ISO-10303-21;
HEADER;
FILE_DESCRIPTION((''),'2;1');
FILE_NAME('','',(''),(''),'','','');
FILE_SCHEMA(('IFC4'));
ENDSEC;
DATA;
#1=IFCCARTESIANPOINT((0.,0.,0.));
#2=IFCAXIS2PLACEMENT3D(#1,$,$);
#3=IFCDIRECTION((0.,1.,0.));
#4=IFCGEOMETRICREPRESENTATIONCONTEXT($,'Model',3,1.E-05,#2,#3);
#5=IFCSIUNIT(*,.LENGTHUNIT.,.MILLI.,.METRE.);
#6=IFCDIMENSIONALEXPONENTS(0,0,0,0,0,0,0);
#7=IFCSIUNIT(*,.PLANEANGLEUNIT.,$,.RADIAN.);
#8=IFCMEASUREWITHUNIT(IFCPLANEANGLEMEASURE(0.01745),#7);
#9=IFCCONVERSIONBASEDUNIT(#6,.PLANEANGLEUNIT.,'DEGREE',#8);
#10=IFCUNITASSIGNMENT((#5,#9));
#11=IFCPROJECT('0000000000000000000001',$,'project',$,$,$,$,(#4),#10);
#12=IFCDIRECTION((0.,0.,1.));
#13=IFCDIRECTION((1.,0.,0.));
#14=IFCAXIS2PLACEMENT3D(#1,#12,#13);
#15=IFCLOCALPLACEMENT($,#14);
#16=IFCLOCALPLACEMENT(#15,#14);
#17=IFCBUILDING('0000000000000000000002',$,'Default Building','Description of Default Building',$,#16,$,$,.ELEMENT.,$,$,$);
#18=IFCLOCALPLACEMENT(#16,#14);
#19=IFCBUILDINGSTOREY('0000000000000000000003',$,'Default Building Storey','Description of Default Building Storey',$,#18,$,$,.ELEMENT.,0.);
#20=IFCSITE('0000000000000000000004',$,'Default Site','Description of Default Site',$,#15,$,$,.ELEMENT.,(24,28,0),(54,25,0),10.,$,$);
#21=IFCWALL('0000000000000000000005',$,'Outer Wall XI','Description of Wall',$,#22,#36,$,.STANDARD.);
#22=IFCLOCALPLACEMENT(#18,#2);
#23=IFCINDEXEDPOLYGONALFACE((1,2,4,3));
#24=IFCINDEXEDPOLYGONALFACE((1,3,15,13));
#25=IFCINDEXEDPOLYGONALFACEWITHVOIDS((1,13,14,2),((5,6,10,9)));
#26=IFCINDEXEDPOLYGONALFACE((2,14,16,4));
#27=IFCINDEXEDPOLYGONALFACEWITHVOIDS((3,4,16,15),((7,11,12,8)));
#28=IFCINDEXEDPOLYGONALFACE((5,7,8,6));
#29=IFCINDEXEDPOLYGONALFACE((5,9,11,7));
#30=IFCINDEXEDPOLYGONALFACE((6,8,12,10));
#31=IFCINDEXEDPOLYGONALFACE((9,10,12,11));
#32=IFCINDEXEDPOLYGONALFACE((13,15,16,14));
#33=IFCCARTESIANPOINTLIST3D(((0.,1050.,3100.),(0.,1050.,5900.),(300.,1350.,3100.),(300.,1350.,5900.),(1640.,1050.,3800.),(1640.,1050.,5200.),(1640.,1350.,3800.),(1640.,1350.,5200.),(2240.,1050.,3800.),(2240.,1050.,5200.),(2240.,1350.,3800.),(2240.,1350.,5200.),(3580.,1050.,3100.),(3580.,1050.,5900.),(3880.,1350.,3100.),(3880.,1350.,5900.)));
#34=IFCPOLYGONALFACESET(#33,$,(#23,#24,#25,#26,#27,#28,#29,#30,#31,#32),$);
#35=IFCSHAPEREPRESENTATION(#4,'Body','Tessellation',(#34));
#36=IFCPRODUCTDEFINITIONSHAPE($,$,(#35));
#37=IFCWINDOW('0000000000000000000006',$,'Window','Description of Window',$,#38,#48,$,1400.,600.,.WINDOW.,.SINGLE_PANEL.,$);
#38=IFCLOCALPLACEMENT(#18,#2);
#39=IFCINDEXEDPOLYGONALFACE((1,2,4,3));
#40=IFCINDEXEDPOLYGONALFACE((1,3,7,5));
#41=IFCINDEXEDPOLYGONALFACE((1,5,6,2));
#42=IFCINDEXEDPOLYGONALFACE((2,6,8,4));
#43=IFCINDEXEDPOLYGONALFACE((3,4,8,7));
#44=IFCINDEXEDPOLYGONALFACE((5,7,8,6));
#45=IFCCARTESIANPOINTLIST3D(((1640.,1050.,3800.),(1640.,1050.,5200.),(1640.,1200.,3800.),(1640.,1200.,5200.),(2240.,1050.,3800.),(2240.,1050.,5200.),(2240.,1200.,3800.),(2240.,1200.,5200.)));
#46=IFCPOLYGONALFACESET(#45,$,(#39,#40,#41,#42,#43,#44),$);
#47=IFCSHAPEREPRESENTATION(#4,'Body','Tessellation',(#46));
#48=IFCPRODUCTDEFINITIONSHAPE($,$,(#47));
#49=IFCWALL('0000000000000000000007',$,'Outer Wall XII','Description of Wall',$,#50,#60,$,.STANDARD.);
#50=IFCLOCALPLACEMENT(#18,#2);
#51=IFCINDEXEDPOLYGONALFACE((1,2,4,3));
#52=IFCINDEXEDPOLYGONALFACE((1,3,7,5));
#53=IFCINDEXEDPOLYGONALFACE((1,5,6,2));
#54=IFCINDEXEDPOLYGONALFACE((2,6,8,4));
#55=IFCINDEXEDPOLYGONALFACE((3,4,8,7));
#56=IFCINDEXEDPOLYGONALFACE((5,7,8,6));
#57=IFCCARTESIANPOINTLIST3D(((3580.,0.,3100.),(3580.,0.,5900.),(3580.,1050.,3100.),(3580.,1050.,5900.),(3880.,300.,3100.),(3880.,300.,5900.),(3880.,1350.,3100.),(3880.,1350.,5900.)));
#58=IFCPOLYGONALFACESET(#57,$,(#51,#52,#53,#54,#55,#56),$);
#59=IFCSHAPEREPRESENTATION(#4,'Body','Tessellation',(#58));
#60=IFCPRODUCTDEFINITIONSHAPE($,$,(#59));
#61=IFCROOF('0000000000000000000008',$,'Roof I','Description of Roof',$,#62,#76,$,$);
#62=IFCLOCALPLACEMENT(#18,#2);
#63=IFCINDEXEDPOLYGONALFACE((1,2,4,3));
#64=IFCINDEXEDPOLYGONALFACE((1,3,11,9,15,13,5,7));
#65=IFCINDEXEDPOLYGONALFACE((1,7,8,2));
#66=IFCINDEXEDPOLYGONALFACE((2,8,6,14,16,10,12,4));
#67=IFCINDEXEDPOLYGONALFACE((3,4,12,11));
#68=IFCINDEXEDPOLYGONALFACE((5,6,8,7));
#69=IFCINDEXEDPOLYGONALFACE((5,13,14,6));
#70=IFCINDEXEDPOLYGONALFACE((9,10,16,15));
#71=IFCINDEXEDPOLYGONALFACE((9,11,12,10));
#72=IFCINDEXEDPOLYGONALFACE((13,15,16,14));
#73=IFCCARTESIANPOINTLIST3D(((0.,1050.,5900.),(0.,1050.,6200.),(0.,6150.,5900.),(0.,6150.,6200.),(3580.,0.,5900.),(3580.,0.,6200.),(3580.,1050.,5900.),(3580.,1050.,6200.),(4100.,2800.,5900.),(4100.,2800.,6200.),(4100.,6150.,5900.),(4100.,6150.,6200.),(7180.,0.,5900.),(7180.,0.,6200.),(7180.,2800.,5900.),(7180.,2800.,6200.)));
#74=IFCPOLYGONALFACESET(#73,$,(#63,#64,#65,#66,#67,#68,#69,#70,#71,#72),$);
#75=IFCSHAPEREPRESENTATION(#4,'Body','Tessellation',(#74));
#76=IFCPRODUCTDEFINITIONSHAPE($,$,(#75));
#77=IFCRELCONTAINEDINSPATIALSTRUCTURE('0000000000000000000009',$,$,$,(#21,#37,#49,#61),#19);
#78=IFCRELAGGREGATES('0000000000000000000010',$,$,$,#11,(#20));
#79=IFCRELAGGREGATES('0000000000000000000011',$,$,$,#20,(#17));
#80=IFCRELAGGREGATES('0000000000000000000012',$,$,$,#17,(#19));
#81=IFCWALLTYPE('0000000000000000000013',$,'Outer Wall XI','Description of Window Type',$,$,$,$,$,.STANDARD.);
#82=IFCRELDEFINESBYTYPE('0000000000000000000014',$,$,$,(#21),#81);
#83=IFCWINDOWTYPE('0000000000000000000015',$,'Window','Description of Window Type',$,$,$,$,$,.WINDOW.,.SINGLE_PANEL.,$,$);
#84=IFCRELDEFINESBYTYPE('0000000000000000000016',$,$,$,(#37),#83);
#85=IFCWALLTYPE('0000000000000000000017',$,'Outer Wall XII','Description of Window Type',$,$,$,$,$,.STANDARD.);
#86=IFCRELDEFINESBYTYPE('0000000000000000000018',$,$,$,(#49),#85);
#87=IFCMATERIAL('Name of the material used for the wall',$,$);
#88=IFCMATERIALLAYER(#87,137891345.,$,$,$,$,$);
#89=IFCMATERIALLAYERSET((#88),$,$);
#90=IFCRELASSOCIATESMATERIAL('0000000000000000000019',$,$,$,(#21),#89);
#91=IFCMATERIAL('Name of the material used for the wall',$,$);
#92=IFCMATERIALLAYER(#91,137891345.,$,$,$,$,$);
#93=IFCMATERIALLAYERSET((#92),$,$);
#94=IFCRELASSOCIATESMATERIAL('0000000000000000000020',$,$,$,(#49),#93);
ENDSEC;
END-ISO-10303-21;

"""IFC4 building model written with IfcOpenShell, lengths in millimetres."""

from ifc_helpers import new_model, entity, si_unit, converted_unit, direction, frame, origin, origin_with_axes, place, context, project, spatial, polyline, outline, extrude, material, layer, layer_set, layer_usage, type_object, element, fill, save


model = new_model("IFC4")

# Units and contexts
model_context = context("Model", 3, precision=1e-05, world=origin(), true_north=direction((0.0, 1.0, 0.0)))
ifc_project = project(units=[si_unit("LENGTHUNIT", "METRE", prefix="MILLI"), converted_unit("PLANEANGLEUNIT", "DEGREE", entity("IfcPlaneAngleMeasure", 0.01745), si_unit("PLANEANGLEUNIT", "RADIAN"), dimensions=[0, 0, 0, 0, 0, 0, 0])], contexts=[model_context])

# Site, building, storey
site_placement = place(None, origin_with_axes())
site = spatial("IfcSite", under=ifc_project, at=site_placement, Name="Default Site", Description="Description of Default Site", CompositionType="ELEMENT", RefLatitude=(24, 28, 0), RefLongitude=(54, 25, 0), RefElevation=10.0)
building_placement = place(site_placement, origin_with_axes())
building = spatial("IfcBuilding", under=site, at=building_placement, Name="Default Building", Description="Description of Default Building", CompositionType="ELEMENT")
storey_placement = place(building_placement, origin_with_axes())
storey = spatial("IfcBuildingStorey", under=building, at=storey_placement, Name="Default Building Storey", Description="Description of Default Building Storey", CompositionType="ELEMENT", Elevation=0.0)

# Wall, opening, window
ifc_material_1 = material(Name="Name of the material used for the wall")
ifc_layer_1 = layer(ifc_material_1, 137891345.0)
ifc_layer_set_1 = layer_set([ifc_layer_1])
ifc_layer_usage_1 = layer_usage(ifc_layer_set_1, "AXIS2", "POSITIVE", -68945672.5)
wall_type_1 = type_object("IfcWallType", Name="Outer Wall XI", Description="Description of Window Type", PredefinedType="STANDARD")
wall_1_placement = place(storey_placement, frame((150.0, 1200.0, 3100.0), z_axis=(0.0, 0.0, 1.0), x_axis=(1.0, 0.0, 0.0)))
wall_1 = element("IfcWall", 1, at=wall_1_placement, inside=storey, type_object=wall_type_1, material=ifc_layer_usage_1, Name="Outer Wall XI", Description="Description of Wall", PredefinedType="STANDARD", context=model_context, shape_type="SweptSolid", body=[
    extrude(outline(polyline([(-150.0, -150.0), (150.0, 150.0), (3730.0, 150.0), (3430.0, -150.0), (-150.0, -150.0)])), origin_with_axes(), (0.0, 0.0, 1.0), 2800.0),
])
opening_1_placement = place(wall_1_placement, frame((1490.0, -150.0, 700.0), z_axis=(0.0, 0.0, 1.0), x_axis=(1.0, 0.0, 0.0)))
opening_1 = element("IfcOpeningElement", 2, at=opening_1_placement, cuts=wall_1, context=model_context, shape_type="SweptSolid", body=[
    extrude(outline(polyline([(0.0, 0.0), (0.0, 300.0), (600.0, 300.0), (600.0, 0.0), (0.0, 0.0)])), origin_with_axes(), (0.0, 0.0, 1.0), 1400.0),
])
window_type_1 = type_object("IfcWindowType", Name="Window", Description="Description of Window Type", PartitioningType="SINGLE_PANEL", PredefinedType="WINDOW")
window_1_placement = place(opening_1_placement, origin_with_axes())
window_1 = element("IfcWindow", 3, at=window_1_placement, inside=storey, type_object=window_type_1, Name="Window", Description="Description of Window", OverallHeight=1400.0, OverallWidth=600.0, PartitioningType="SINGLE_PANEL", PredefinedType="WINDOW", context=model_context, shape_type="SweptSolid", body=[
    extrude(outline(polyline([(0.0, 0.0), (0.0, 150.0), (600.0, 150.0), (600.0, 0.0), (0.0, 0.0)])), origin_with_axes(), (0.0, 0.0, 1.0), 1400.0),
])
fill(opening_1, window_1)

# Wall
ifc_material_2 = material(Name="Name of the material used for the wall")
ifc_layer_2 = layer(ifc_material_2, 137891345.0)
ifc_layer_set_2 = layer_set([ifc_layer_2])
ifc_layer_usage_2 = layer_usage(ifc_layer_set_2, "AXIS2", "POSITIVE", -68945672.5)
wall_type_2 = type_object("IfcWallType", Name="Outer Wall XII", Description="Description of Window Type", PredefinedType="STANDARD")
wall_2_placement = place(storey_placement, frame((3730.0, 1200.0, 3100.0), z_axis=(0.0, 0.0, 1.0), x_axis=(0.0, -1.0, 0.0)))
element("IfcWall", 4, at=wall_2_placement, inside=storey, type_object=wall_type_2, material=ifc_layer_usage_2, Name="Outer Wall XII", Description="Description of Wall", PredefinedType="STANDARD", context=model_context, shape_type="SweptSolid", body=[
    extrude(outline(polyline([(150.0, -150.0), (-150.0, 150.0), (900.0, 150.0), (1200.0, -150.0), (150.0, -150.0)])), origin_with_axes(), (0.0, 0.0, 1.0), 2800.0),
])

# Roof
roof_placement = place(storey_placement, frame((0.0, 0.0, 5900.0), z_axis=(0.0, 0.0, 1.0), x_axis=(1.0, 0.0, 0.0)))
element("IfcRoof", 5, at=roof_placement, inside=storey, Name="Roof I", Description="Description of Roof", context=model_context, shape_type="SweptSolid", body=[
    extrude(outline(polyline([(0.0, 1050.0), (0.0, 6150.0), (4100.0, 6150.0), (4100.0, 2800.0), (7180.0, 2800.0), (7180.0, 0.0), (3580.0, 0.0), (3580.0, 1050.0), (0.0, 1050.0)])), origin_with_axes(), (0.0, 0.0, 1.0), 300.0),
])

save(model, "model.ifc")
